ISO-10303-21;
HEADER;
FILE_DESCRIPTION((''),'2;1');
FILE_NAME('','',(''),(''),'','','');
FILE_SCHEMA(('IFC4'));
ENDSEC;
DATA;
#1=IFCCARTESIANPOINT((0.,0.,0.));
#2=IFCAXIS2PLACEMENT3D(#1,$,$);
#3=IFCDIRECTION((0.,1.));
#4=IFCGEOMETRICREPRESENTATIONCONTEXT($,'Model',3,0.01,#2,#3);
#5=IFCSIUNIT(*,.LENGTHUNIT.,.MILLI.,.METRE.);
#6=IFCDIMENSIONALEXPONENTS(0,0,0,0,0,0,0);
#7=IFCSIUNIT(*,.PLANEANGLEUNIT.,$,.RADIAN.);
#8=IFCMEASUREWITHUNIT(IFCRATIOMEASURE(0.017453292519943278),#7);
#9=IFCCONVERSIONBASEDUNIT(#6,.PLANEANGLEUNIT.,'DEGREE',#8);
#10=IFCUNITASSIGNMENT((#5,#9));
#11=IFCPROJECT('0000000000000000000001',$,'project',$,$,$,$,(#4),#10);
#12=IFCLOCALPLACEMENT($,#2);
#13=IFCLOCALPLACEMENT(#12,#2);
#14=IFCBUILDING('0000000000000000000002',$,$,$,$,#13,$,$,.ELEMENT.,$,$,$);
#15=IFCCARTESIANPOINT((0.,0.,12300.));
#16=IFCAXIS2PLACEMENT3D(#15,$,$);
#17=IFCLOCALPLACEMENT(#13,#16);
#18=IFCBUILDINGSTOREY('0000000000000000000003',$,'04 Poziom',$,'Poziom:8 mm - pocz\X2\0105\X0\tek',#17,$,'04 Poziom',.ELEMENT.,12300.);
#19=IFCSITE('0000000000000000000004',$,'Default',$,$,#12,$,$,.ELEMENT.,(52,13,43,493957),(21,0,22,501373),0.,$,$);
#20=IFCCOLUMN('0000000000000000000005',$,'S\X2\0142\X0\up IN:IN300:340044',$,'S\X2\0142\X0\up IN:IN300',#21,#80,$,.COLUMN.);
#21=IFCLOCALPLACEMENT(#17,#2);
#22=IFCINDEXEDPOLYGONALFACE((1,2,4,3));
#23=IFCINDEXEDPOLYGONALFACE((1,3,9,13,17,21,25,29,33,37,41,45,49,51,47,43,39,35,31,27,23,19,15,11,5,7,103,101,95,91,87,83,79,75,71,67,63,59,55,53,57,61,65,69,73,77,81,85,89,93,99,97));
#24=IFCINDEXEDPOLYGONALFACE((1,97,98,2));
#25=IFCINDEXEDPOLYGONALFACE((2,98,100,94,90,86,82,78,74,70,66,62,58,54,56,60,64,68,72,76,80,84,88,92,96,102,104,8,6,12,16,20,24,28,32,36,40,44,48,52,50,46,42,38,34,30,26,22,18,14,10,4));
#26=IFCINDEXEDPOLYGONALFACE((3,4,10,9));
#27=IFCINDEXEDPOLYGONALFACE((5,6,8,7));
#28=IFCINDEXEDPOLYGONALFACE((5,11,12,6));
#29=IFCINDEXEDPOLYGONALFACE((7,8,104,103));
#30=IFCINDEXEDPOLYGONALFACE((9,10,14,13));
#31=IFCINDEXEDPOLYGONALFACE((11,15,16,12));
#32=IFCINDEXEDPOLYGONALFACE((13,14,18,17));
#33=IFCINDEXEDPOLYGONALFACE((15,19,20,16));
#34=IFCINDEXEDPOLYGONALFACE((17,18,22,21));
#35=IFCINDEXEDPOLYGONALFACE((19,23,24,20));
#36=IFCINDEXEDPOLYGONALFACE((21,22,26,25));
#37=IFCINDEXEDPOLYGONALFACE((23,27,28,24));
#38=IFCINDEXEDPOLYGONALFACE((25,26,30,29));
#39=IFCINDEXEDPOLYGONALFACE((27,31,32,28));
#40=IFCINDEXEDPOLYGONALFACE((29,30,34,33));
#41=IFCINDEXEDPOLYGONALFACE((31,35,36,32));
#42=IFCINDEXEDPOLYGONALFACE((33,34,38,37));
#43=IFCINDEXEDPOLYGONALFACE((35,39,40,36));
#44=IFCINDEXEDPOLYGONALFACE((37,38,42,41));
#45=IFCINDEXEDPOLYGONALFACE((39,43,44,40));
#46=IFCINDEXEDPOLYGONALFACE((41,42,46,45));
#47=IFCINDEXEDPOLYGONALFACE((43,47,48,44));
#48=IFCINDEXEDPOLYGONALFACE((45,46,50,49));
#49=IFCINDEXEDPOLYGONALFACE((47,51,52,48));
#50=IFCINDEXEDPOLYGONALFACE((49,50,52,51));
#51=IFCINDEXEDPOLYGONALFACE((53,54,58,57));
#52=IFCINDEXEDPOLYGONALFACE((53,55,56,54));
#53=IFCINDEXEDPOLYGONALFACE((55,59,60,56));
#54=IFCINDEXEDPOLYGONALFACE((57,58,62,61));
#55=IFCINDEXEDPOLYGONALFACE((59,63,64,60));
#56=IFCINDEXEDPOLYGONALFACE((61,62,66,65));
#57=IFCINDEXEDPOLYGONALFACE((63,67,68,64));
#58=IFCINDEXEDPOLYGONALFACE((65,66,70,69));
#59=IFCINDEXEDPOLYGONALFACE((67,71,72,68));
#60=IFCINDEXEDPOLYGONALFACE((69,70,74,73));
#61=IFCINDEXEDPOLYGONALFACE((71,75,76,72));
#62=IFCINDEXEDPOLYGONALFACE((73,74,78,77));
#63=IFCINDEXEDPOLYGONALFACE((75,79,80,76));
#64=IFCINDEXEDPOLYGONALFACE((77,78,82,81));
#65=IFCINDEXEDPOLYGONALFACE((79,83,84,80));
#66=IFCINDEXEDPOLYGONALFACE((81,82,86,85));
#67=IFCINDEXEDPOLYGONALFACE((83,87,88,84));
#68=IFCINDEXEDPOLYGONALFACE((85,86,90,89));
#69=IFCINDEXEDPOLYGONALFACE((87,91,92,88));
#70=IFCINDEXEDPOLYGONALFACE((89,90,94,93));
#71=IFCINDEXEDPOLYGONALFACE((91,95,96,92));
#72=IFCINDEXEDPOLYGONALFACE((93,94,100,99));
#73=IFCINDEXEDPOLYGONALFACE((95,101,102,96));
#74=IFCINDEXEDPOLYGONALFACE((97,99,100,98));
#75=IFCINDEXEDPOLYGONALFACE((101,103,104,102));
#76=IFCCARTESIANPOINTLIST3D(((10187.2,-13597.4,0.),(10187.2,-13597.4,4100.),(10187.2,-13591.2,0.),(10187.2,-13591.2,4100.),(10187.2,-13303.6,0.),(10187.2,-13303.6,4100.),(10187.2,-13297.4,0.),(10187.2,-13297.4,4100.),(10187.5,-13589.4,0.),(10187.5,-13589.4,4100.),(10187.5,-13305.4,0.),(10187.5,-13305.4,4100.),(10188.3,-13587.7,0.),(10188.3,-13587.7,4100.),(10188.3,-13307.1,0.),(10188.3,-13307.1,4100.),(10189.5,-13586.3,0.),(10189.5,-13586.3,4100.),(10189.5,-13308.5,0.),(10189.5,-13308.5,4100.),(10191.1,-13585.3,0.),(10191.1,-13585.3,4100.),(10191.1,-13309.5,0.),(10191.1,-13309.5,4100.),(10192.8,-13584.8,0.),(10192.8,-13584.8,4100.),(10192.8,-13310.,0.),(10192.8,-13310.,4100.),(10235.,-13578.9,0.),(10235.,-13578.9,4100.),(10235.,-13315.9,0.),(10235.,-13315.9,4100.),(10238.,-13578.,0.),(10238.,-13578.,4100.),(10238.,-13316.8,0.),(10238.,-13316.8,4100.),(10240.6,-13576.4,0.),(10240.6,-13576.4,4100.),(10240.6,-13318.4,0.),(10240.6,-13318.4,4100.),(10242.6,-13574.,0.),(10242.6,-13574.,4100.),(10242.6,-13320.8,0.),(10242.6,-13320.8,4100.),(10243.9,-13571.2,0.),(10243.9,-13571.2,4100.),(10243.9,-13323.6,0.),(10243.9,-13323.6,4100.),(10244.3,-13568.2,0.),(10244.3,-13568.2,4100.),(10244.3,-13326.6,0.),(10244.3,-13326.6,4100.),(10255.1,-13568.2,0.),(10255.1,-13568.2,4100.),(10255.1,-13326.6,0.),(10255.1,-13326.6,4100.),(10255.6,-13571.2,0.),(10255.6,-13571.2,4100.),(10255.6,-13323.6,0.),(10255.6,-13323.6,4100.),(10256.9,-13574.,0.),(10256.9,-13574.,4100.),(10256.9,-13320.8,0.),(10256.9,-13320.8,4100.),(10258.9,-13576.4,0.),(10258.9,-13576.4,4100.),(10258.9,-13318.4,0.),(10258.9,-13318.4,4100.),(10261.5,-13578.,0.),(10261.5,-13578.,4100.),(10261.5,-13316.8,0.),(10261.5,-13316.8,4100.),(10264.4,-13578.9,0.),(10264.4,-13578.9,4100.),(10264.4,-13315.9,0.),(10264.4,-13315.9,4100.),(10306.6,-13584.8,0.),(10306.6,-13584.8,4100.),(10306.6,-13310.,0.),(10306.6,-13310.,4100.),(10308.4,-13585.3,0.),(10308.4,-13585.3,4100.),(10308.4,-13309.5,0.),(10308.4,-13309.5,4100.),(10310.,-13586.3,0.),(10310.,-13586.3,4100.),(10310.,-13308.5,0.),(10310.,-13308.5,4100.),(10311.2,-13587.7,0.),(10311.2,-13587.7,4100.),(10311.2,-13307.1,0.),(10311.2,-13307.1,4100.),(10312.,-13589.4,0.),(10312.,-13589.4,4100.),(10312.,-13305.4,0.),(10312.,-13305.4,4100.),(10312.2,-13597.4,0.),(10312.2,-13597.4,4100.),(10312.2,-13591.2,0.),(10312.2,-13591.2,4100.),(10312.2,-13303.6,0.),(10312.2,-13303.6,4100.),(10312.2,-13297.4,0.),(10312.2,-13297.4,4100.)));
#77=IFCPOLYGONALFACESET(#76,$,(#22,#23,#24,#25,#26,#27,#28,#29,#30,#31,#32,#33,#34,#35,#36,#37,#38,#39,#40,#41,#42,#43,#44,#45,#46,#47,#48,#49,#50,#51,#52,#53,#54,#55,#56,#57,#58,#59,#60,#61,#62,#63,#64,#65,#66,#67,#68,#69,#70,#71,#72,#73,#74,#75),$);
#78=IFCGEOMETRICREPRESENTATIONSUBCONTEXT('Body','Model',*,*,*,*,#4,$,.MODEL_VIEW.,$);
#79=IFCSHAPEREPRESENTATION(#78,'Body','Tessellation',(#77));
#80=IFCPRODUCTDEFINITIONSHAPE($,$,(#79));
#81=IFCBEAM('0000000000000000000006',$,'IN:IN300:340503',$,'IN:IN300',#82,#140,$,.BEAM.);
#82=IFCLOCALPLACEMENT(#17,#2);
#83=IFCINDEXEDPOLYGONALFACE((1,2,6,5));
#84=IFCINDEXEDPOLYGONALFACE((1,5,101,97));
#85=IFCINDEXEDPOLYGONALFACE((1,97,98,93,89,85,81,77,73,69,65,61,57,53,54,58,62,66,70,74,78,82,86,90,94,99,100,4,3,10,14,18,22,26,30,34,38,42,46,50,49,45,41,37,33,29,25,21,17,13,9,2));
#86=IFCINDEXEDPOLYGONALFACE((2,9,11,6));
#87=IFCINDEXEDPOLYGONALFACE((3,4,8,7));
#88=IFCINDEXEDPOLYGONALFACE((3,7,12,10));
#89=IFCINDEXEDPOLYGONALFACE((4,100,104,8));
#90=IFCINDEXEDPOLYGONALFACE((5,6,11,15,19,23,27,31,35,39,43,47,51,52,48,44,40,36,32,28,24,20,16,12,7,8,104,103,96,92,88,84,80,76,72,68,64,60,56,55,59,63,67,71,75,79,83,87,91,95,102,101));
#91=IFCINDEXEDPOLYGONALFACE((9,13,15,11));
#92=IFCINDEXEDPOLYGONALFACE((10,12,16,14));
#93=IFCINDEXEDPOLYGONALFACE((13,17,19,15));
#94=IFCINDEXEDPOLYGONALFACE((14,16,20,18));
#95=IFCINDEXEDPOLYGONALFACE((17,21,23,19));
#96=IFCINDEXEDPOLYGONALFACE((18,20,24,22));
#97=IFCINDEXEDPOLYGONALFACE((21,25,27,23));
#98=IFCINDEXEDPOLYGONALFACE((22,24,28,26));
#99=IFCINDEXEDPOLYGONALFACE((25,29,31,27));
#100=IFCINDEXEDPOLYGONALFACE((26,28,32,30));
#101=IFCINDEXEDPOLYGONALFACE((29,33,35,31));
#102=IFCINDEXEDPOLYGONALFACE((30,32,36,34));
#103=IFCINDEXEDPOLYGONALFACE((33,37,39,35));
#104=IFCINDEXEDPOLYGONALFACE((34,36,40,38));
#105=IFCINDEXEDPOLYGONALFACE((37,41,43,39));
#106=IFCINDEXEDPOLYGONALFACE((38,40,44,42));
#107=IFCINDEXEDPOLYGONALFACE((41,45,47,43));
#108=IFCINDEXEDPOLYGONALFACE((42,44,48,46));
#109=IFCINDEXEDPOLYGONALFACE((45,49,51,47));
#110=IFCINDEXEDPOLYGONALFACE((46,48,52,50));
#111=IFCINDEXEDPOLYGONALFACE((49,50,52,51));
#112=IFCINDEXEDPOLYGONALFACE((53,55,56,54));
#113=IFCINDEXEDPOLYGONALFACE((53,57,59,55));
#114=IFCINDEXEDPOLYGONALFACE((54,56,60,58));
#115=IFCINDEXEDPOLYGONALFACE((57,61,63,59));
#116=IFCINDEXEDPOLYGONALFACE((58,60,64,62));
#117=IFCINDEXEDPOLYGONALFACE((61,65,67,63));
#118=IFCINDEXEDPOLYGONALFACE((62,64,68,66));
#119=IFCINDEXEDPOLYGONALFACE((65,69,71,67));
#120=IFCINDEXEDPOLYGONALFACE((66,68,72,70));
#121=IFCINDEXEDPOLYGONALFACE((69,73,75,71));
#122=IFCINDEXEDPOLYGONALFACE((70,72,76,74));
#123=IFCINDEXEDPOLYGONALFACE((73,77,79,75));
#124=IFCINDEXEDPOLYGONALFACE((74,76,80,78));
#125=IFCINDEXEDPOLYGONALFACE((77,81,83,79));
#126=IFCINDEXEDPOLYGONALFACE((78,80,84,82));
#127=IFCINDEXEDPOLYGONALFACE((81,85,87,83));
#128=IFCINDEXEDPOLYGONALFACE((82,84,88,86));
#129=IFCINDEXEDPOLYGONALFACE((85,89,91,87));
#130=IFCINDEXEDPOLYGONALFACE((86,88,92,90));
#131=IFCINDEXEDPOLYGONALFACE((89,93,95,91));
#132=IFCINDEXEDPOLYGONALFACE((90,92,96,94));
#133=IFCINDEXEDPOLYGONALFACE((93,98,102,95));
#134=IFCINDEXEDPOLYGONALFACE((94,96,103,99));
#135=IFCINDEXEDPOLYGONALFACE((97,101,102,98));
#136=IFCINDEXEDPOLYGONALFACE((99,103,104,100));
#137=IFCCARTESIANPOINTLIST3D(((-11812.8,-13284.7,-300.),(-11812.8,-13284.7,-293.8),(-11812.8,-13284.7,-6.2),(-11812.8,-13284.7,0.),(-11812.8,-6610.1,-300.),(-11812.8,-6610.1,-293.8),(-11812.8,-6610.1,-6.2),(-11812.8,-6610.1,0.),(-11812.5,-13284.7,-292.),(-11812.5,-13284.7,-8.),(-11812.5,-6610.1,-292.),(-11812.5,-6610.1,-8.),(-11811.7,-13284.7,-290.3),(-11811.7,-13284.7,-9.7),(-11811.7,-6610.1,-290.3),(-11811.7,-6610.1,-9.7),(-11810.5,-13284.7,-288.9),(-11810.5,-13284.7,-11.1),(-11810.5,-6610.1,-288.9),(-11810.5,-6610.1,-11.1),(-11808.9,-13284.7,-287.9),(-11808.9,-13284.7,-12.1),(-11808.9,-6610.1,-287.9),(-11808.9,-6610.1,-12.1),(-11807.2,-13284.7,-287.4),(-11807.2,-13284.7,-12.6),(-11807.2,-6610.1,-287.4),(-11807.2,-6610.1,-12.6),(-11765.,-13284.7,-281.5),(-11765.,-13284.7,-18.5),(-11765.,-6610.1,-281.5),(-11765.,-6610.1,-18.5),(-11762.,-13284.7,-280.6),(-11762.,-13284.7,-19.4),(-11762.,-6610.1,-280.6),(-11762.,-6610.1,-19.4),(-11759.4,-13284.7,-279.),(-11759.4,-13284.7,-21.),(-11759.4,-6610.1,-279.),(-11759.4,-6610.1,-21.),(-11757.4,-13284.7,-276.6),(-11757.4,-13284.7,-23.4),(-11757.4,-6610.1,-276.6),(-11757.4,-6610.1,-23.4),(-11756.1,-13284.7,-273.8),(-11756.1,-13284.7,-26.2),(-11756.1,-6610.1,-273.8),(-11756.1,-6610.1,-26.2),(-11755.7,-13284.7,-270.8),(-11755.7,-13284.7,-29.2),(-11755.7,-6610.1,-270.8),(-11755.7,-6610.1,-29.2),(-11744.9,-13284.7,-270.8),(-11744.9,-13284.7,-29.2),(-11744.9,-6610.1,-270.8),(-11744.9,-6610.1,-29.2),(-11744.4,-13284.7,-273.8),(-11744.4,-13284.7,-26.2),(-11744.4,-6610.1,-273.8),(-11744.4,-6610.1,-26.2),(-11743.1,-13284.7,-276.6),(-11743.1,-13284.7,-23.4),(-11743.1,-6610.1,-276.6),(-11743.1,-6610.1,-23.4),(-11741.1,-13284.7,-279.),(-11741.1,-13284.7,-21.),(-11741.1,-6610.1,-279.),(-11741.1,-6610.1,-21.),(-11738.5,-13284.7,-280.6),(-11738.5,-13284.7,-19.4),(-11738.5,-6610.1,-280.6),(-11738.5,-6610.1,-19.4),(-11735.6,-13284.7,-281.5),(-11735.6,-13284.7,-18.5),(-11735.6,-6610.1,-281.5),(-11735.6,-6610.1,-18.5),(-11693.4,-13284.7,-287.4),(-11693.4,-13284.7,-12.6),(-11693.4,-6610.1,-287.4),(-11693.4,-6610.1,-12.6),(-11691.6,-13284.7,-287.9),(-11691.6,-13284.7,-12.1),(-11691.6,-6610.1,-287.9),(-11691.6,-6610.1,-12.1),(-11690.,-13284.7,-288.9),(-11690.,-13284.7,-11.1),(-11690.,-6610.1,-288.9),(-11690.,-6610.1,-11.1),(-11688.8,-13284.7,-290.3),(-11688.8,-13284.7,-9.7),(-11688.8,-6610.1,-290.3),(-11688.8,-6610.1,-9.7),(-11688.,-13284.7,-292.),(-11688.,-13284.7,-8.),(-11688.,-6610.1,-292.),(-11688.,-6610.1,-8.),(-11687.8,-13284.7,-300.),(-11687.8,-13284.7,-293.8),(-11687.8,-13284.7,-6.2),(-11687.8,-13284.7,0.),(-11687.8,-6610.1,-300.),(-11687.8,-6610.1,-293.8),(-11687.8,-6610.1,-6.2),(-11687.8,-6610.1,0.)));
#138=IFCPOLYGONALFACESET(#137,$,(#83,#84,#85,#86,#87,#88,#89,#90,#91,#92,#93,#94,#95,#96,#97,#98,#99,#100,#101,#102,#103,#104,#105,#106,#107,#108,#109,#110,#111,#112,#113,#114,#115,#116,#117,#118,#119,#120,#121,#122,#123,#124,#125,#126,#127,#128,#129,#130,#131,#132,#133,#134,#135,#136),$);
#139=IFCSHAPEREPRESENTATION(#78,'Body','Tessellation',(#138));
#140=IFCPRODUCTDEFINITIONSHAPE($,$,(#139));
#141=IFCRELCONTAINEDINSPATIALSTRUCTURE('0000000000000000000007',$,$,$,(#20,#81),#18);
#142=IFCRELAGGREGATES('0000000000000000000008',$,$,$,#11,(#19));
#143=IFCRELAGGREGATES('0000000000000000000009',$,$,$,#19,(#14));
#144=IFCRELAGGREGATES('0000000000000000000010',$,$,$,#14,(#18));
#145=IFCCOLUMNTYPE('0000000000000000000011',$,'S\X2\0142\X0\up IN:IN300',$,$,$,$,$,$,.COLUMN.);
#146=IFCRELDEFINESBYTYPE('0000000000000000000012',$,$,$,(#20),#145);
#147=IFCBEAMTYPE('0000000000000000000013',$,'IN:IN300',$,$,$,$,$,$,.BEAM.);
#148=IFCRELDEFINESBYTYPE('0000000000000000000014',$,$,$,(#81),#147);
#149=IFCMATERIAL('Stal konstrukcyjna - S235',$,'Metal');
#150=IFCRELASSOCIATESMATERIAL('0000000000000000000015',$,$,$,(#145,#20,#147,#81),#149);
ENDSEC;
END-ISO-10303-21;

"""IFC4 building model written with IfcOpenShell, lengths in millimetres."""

from ifc_helpers import new_model, entity, si_unit, converted_unit, direction, frame, origin, place, context, subcontext, project, spatial, line, arc, indexed_curve, outline, extrude, source, transform, mapped, material, type_object, type_shapes, element, save


model = new_model("IFC4")

# Units and contexts
model_context = context("Model", 3, precision=0.01, world=origin(), true_north=direction((0.0, 1.0)))
body_context = subcontext(model_context, "Body", "Model", "MODEL_VIEW")
ifc_project = project(units=[si_unit("LENGTHUNIT", "METRE", prefix="MILLI"), converted_unit("PLANEANGLEUNIT", "DEGREE", entity("IfcRatioMeasure", 0.017453292519943278), si_unit("PLANEANGLEUNIT", "RADIAN"), dimensions=[0, 0, 0, 0, 0, 0, 0])], contexts=[model_context])

# Site, building, storey
site_placement = place(None, origin())
site = spatial("IfcSite", under=ifc_project, at=site_placement, Name="Default", CompositionType="ELEMENT", RefLatitude=(52, 13, 43, 493957), RefLongitude=(21, 0, 22, 501373), RefElevation=0.0)
building_placement = place(site_placement, origin())
building = spatial("IfcBuilding", under=site, at=building_placement, CompositionType="ELEMENT")
storey_placement = place(building_placement, frame((0.0, 0.0, 12300.0)))
storey = spatial("IfcBuildingStorey", under=building, at=storey_placement, Name="04 Poziom", ObjectType="Poziom:8 mm - początek", LongName="04 Poziom", CompositionType="ELEMENT", Elevation=12300.0)

# Column
ifc_material = material(Name="Stal konstrukcyjna - S235", Category="Metal")
column_type = type_object("IfcColumnType", Name="Słup IN:IN300", PredefinedType="COLUMN", material=ifc_material)
shared_shape_1 = source(origin(), body_context, "Body", "SweptSolid", [
    extrude(outline(indexed_curve([(143.8, -62.5), (150.0, -62.5), (150.0, 62.5), (143.8, 62.5), (139.6, 60.9), (137.4, 56.9), (131.5, 14.7), (127.9, 8.1), (120.8, 5.4), (-120.8, 5.4), (-127.9, 8.1), (-131.5, 14.7), (-137.4, 56.9), (-139.6, 60.9), (-143.8, 62.5), (-150.0, 62.5), (-150.0, -62.5), (-143.8, -62.5), (-139.6, -60.9), (-137.4, -56.9), (-131.5, -14.7), (-127.9, -8.1), (-120.8, -5.4), (120.8, -5.4), (127.9, -8.1), (131.5, -14.7), (137.4, -56.9), (139.6, -60.9)], segments=[line(1, 2, 3, 4), arc(4, 5, 6), line(6, 7), arc(7, 8, 9), line(9, 10), arc(10, 11, 12), line(12, 13), arc(13, 14, 15), line(15, 16, 17, 18), arc(18, 19, 20), line(20, 21), arc(21, 22, 23), line(23, 24), arc(24, 25, 26), line(26, 27), arc(27, 28, 1)], self_intersect=False)), frame((0.0, 0.0, 12300.0), z_axis=(0.0, 0.0, 1.0), x_axis=(0.0, -1.0, 0.0)), (0.0, 0.0, 1.0), 4100.0),
])
type_shapes(column_type, [shared_shape_1])
for number, where, name in (
    (1, (10249.7, -13447.4, -12300.0), "Słup IN:IN300:340044"),
):
    element("IfcColumn", number, at=place(storey_placement, frame(where)), inside=storey, type_object=column_type, material=ifc_material, Name=name, ObjectType="Słup IN:IN300", PredefinedType="COLUMN", context=body_context, shape_type="MappedRepresentation", body=[
        mapped(shared_shape_1, transform((0.0, 0.0, 0.0), scale=1.0)),
    ])

# Beam
beam_type_1 = type_object("IfcBeamType", Name="IN:IN300", PredefinedType="BEAM", material=ifc_material)
shared_shape_2 = source(origin(), body_context, "Body", "SweptSolid", [
    extrude(outline(indexed_curve([(143.8, -62.5), (150.0, -62.5), (150.0, 62.5), (143.8, 62.5), (139.6, 60.9), (137.4, 56.9), (131.5, 14.7), (127.9, 8.1), (120.8, 5.4), (-120.8, 5.4), (-127.9, 8.1), (-131.5, 14.7), (-137.4, 56.9), (-139.6, 60.9), (-143.8, 62.5), (-150.0, 62.5), (-150.0, -62.5), (-143.8, -62.5), (-139.6, -60.9), (-137.4, -56.9), (-131.5, -14.7), (-127.9, -8.1), (-120.8, -5.4), (120.8, -5.4), (127.9, -8.1), (131.5, -14.7), (137.4, -56.9), (139.6, -60.9)], segments=[line(1, 2, 3, 4), arc(4, 5, 6), line(6, 7), arc(7, 8, 9), line(9, 10), arc(10, 11, 12), line(12, 13), arc(13, 14, 15), line(15, 16, 17, 18), arc(18, 19, 20), line(20, 21), arc(21, 22, 23), line(23, 24), arc(24, 25, 26), line(26, 27), arc(27, 28, 1)], self_intersect=False)), frame((-3337.3, 0.0, 0.0), z_axis=(1.0, 0.0, 0.0), x_axis=(0.0, 0.0, -1.0)), (0.0, 0.0, 1.0), 6674.6),
])
type_shapes(beam_type_1, [shared_shape_2])
for number, where, z_axis, x_axis, name in (
    (2, (-11750.3, -9947.4, -150.0), (0.0, 0.0, 1.0), (0.0, 1.0, 0.0), "IN:IN300:340503"),
):
    element("IfcBeam", number, at=place(storey_placement, frame(where, z_axis=z_axis, x_axis=x_axis)), inside=storey, type_object=beam_type_1, material=ifc_material, Name=name, ObjectType="IN:IN300", PredefinedType="BEAM", context=body_context, shape_type="MappedRepresentation", body=[
        mapped(shared_shape_2, transform((0.0, 0.0, 0.0), scale=1.0)),
    ])

save(model, "model.ifc")
